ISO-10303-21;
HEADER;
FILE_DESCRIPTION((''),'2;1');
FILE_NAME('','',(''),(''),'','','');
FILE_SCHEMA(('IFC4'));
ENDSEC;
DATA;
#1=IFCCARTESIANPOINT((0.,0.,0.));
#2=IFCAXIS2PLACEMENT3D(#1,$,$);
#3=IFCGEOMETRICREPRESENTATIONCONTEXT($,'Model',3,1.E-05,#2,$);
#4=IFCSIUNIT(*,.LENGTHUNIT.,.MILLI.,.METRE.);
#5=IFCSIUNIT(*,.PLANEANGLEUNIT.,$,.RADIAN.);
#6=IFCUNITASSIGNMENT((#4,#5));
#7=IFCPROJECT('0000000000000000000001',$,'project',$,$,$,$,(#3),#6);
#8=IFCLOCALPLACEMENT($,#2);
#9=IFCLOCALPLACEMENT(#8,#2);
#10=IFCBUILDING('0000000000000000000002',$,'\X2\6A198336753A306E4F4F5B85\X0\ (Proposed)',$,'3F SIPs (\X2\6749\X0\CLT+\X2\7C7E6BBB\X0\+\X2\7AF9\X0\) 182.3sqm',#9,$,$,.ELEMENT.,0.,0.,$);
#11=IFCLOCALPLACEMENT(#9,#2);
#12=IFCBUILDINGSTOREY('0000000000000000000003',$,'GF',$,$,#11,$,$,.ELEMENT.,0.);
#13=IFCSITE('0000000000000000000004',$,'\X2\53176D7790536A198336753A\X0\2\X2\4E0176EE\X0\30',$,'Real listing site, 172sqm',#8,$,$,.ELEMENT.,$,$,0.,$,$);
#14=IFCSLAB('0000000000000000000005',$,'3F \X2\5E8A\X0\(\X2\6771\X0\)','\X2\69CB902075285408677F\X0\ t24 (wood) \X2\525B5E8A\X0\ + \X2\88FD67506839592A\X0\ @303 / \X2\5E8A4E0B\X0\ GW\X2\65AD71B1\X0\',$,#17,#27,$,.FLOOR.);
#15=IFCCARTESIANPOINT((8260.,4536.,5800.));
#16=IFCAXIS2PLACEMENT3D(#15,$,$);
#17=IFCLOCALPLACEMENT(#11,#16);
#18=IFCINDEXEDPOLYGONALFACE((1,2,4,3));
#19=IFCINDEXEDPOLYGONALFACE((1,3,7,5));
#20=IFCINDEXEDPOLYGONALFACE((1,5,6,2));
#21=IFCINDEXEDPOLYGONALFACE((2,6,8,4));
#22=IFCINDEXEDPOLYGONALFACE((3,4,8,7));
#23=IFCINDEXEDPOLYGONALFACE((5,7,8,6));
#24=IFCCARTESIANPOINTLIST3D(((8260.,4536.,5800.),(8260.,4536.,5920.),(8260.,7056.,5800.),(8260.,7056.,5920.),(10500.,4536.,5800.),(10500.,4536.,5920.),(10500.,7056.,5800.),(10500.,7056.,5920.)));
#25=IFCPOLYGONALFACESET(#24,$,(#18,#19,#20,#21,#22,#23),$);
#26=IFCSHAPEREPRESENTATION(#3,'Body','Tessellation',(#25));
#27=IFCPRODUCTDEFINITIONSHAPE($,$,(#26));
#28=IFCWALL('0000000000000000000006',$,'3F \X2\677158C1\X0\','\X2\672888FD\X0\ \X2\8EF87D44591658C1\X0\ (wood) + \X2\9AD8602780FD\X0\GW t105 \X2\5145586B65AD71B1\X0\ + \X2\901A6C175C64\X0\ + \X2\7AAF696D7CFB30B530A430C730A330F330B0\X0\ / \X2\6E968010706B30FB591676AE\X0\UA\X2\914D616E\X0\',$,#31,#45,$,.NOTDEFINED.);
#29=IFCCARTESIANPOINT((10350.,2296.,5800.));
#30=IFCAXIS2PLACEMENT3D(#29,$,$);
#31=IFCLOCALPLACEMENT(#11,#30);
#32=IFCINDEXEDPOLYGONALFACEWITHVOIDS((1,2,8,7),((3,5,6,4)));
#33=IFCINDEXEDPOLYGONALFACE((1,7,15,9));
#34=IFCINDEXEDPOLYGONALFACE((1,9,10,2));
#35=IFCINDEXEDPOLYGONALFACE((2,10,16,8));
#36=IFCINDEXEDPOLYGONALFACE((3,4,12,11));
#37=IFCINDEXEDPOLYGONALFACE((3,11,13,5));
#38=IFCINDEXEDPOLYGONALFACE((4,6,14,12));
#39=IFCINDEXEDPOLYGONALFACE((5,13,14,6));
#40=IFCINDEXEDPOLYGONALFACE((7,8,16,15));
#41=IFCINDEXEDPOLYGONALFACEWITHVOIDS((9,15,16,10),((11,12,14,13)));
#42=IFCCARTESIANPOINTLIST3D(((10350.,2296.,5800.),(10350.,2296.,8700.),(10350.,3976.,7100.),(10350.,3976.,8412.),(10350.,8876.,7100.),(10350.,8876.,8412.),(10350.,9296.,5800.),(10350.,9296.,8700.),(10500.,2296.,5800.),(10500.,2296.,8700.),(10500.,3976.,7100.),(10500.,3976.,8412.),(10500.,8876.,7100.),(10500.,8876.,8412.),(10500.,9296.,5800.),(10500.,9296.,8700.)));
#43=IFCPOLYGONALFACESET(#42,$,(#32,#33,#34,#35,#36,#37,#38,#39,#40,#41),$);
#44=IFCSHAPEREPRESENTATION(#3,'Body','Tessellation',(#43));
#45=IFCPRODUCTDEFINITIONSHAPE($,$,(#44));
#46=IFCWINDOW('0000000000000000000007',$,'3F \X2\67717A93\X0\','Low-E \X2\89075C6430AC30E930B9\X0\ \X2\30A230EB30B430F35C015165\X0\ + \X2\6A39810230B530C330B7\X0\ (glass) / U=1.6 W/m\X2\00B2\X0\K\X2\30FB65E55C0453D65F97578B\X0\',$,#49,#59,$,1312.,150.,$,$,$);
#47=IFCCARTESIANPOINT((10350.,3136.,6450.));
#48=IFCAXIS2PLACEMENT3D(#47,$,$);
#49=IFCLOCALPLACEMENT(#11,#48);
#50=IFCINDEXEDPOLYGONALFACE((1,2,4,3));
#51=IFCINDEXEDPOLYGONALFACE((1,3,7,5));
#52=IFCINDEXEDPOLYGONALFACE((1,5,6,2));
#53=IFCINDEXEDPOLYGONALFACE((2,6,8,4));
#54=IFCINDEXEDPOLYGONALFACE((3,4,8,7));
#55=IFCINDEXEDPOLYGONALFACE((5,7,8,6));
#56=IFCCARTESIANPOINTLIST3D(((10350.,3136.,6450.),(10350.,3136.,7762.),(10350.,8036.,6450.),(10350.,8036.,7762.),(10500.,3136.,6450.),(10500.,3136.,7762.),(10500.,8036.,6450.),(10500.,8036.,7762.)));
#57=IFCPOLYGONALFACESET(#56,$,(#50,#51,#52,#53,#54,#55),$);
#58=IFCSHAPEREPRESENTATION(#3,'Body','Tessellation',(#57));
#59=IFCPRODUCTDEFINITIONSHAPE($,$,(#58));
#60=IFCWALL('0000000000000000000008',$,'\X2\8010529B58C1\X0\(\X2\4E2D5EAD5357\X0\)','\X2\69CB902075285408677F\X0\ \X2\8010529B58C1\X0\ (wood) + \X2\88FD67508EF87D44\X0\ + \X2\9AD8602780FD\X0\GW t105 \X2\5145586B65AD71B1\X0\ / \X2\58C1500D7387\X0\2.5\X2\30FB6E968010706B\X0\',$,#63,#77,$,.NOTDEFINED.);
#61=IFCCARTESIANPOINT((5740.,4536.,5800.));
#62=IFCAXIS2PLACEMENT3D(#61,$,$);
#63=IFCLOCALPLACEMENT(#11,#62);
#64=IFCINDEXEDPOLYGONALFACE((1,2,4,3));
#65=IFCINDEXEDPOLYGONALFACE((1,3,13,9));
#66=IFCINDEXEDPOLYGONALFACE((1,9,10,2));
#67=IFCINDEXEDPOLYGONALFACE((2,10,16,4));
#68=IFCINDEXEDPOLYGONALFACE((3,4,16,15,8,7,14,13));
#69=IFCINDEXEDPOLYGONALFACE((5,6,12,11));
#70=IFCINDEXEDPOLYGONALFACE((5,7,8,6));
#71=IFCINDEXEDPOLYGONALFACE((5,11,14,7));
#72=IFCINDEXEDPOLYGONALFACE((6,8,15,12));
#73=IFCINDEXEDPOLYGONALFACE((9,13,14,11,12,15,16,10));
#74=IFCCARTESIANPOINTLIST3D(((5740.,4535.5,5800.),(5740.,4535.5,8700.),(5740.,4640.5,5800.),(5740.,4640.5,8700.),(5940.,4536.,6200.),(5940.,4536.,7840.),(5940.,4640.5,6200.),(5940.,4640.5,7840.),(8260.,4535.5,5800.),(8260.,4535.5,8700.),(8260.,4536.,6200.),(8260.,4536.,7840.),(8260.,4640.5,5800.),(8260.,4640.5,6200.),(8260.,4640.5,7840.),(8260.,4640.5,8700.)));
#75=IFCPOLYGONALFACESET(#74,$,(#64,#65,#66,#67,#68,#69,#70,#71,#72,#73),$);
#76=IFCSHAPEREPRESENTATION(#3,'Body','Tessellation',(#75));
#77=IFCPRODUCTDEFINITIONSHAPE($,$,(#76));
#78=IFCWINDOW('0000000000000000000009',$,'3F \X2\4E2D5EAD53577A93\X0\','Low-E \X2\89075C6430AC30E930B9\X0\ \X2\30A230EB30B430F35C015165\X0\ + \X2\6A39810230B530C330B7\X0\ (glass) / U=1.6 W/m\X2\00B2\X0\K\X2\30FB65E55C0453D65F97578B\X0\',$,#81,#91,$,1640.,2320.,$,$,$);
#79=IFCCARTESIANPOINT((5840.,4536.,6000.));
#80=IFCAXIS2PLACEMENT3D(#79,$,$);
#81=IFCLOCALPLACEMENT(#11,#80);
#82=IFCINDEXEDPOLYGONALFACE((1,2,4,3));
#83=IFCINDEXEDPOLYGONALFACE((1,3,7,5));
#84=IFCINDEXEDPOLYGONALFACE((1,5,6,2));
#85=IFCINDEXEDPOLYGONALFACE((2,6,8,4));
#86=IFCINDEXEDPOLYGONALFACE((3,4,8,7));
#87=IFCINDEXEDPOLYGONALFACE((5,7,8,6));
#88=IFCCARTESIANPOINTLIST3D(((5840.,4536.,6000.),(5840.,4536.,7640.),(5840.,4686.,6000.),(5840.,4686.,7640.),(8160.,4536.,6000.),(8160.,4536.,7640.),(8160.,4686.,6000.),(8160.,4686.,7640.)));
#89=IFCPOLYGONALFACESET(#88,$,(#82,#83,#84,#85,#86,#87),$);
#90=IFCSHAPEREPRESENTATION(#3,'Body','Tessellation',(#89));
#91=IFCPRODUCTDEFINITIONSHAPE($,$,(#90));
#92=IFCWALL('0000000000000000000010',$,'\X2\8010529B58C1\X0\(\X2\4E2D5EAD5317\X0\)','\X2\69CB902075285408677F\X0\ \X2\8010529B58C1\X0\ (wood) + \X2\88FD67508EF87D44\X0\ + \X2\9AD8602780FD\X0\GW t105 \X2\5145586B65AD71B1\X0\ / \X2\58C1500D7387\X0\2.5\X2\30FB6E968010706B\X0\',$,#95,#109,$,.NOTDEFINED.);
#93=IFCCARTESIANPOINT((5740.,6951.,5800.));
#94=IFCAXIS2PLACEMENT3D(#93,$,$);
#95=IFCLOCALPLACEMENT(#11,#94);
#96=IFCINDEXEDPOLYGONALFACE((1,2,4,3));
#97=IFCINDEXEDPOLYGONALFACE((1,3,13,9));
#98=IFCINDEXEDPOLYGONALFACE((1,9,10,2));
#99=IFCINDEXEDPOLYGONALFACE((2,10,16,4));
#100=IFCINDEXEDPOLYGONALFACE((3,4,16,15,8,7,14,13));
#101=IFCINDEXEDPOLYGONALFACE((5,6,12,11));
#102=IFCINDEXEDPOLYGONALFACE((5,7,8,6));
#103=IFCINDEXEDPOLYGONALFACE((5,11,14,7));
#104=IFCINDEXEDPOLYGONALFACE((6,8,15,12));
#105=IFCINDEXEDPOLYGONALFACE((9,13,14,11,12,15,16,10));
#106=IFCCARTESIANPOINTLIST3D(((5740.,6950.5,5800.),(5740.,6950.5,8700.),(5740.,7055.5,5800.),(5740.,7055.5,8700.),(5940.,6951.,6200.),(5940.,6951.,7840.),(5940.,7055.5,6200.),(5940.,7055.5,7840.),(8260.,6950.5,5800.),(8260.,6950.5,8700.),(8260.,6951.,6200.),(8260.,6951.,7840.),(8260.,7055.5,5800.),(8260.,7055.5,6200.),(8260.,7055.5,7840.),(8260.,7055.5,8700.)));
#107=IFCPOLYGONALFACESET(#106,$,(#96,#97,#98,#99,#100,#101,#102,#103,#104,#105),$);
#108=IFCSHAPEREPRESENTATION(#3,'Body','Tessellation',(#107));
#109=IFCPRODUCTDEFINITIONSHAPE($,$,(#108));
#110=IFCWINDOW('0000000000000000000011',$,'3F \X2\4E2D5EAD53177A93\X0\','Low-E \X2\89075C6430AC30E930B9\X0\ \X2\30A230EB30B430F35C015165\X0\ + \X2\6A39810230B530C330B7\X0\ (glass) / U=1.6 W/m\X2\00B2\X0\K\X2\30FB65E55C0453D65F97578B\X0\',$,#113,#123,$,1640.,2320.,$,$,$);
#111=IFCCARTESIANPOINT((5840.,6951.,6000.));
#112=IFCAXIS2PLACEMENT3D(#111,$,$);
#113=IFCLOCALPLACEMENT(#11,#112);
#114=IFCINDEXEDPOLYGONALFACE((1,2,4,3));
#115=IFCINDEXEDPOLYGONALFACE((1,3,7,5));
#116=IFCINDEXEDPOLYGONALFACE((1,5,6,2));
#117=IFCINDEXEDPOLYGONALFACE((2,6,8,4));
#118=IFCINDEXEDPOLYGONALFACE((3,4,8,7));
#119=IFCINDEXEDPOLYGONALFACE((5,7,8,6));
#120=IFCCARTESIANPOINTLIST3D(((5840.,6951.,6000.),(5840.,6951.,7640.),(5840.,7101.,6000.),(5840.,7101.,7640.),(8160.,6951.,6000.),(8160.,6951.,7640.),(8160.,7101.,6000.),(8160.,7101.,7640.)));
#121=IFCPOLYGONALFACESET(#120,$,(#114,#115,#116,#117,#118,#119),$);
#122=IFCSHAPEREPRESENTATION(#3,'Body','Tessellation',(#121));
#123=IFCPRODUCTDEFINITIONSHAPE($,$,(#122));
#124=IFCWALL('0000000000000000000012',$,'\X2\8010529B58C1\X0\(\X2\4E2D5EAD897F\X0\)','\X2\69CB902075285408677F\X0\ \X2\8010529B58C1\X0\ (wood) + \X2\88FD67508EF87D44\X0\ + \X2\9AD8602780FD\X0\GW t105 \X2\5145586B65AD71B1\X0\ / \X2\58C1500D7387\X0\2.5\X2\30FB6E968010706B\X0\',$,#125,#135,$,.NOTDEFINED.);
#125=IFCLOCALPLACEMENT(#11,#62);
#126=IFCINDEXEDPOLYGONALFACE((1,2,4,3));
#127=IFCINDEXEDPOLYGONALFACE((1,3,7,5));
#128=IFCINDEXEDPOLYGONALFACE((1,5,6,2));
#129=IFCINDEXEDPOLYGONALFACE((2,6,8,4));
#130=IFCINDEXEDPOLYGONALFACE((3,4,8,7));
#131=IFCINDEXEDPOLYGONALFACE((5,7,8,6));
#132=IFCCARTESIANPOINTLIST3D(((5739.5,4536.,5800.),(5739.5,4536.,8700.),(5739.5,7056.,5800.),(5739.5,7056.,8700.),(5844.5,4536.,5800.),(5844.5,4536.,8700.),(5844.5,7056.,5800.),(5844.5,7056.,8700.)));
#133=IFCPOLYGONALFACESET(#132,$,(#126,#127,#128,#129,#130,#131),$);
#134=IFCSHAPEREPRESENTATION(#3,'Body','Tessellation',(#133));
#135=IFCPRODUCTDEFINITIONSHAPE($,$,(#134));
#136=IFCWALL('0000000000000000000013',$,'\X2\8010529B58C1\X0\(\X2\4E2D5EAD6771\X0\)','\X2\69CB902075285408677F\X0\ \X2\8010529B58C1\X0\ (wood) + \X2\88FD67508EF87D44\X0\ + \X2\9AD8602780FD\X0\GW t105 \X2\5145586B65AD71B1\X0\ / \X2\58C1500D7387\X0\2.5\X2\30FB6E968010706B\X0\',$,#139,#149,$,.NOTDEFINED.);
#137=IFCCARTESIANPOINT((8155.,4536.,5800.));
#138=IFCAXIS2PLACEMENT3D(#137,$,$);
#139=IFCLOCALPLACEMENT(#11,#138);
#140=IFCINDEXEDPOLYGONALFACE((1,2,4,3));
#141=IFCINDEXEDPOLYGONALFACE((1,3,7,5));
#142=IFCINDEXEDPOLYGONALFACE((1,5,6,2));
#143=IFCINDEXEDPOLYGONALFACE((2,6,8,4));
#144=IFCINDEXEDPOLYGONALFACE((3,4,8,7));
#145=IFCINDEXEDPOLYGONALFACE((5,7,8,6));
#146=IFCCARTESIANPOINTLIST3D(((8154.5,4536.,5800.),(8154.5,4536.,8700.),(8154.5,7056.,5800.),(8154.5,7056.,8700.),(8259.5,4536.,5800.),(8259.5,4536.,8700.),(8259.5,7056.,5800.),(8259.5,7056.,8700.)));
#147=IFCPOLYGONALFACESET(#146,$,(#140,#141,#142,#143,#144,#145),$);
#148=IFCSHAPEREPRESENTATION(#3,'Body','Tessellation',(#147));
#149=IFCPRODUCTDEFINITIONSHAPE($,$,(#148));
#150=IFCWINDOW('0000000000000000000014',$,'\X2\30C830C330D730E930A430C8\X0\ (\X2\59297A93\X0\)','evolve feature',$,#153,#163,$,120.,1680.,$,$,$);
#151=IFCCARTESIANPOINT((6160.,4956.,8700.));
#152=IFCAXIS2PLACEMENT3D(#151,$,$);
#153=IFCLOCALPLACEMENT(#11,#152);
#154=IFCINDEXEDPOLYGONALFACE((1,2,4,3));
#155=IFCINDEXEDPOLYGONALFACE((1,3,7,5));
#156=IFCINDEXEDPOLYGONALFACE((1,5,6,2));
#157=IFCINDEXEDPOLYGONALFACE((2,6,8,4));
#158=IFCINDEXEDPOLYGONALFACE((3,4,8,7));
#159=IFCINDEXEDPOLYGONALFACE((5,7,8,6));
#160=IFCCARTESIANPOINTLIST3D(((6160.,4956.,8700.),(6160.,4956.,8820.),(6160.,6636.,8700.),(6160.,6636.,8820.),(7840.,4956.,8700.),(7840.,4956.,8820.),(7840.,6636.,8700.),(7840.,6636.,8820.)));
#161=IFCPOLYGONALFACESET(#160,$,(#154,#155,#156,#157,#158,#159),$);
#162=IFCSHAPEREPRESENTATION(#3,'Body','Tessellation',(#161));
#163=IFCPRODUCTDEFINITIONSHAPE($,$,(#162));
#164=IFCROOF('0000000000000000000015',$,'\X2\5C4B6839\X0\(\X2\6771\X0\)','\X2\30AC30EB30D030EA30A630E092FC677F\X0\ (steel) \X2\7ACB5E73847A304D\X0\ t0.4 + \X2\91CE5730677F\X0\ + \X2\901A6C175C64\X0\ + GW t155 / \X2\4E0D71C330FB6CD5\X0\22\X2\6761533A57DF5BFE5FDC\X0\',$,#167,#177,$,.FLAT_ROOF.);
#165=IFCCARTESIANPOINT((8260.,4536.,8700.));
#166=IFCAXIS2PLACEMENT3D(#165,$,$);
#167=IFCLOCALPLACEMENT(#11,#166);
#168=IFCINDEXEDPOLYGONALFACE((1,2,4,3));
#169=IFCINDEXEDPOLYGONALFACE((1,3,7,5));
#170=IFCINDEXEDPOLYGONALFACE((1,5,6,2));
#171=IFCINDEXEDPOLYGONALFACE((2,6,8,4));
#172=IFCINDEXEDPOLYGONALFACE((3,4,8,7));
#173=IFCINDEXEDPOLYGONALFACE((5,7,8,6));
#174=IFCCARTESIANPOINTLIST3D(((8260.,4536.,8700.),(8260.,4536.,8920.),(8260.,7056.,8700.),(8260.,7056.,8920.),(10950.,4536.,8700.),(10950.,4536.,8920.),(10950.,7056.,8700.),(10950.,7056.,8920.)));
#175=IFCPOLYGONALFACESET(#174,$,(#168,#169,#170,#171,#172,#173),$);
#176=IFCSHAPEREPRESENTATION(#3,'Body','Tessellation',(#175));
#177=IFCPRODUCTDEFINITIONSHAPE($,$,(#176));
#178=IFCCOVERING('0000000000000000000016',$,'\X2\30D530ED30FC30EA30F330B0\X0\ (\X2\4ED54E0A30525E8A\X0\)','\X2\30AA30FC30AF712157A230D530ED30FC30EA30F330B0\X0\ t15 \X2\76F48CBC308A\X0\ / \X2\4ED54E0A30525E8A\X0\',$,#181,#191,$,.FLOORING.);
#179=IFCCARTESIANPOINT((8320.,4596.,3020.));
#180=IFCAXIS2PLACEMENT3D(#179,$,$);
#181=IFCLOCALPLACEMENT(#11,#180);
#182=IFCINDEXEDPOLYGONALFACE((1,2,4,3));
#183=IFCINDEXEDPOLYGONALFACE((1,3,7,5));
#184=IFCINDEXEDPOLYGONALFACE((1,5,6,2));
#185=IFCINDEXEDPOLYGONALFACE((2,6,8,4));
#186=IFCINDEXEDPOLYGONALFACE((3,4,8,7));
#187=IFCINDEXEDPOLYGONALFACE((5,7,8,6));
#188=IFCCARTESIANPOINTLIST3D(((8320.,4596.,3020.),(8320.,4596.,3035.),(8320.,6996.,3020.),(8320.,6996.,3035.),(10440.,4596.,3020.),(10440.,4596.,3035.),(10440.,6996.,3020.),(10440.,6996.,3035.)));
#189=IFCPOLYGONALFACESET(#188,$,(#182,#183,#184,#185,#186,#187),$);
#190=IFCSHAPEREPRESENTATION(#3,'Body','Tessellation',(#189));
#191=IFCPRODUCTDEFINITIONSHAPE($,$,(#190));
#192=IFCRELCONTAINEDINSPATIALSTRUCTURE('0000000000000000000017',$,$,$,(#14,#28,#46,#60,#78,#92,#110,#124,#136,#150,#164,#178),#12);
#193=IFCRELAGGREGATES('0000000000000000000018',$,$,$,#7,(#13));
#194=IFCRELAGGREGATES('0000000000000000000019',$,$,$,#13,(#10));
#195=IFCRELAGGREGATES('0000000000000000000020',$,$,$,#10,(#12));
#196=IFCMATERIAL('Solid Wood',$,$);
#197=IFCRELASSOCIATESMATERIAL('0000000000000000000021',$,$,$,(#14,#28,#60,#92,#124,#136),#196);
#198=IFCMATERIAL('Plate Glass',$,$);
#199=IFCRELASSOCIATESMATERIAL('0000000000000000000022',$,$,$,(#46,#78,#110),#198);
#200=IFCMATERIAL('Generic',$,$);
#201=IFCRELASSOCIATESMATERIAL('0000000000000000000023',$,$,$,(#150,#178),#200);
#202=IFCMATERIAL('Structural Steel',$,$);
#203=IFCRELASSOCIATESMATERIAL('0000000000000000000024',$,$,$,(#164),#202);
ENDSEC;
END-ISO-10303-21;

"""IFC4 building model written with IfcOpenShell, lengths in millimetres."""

from ifc_helpers import new_model, si_unit, frame, frame_2d, origin, place, context, project, spatial, rectangle, extrude, material, element, fill, save


model = new_model("IFC4")

# Units and contexts
model_context = context("Model", 3, precision=1e-05, world=origin())
ifc_project = project(units=[si_unit("LENGTHUNIT", "METRE", prefix="MILLI"), si_unit("PLANEANGLEUNIT", "RADIAN")], contexts=[model_context])

# Site, building, storey
site_placement = place(None, origin())
site = spatial("IfcSite", under=ifc_project, at=site_placement, Name="北海道標茶町2丁目30", ObjectType="Real listing site, 172sqm", CompositionType="ELEMENT", RefElevation=0.0)
building_placement = place(site_placement, origin())
building = spatial("IfcBuilding", under=site, at=building_placement, Name="標茶町の住宅 (Proposed)", ObjectType="3F SIPs (杉CLT+籾殻+竹) 182.3sqm", CompositionType="ELEMENT", ElevationOfRefHeight=0.0, ElevationOfTerrain=0.0)
storey_placement = place(building_placement, origin())
storey = spatial("IfcBuildingStorey", under=building, at=storey_placement, Name="GF", CompositionType="ELEMENT", Elevation=0.0)

# Slab
ifc_material_1 = material(Name="Solid Wood")
slab_placement = place(storey_placement, frame((8260.0, 4536.0, 5800.0)))
element("IfcSlab", 1, at=slab_placement, inside=storey, material=ifc_material_1, Name="3F 床(東)", Description="構造用合板 t24 (wood) 剛床 + 製材根太 @303 / 床下 GW断熱", PredefinedType="FLOOR", context=model_context, shape_type="SweptSolid", body=[
    extrude(rectangle(XDim=2240.0, YDim=2520.0, at=frame_2d((1120.0, 1260.0))), frame((8260.0, 4536.0, 5800.0)), (0.0, 0.0, 1.0), 120.0),
])

# Walls, openings, windows
wall_1_placement = place(storey_placement, frame((10350.0, 2296.0, 5800.0)))
wall_1 = element("IfcWall", 2, at=wall_1_placement, inside=storey, material=ifc_material_1, Name="3F 東壁", Description="木製 軸組外壁 (wood) + 高性能GW t105 充填断熱 + 通気層 + 窯業系サイディング / 準耐火・外皮UA配慮", PredefinedType="NOTDEFINED", context=model_context, shape_type="SweptSolid", body=[
    extrude(rectangle(XDim=150.0, YDim=7000.0, at=frame_2d((75.0, 3500.0))), frame((10350.0, 2296.0, 5800.0)), (0.0, 0.0, 1.0), 2900.0),
])
opening_1_placement = place(storey_placement, frame((10350.0, 3136.0, 6450.0)))
opening_1 = element("IfcOpeningElement", 3, at=opening_1_placement, cuts=wall_1, PredefinedType="NOTDEFINED", context=model_context, shape_type="SweptSolid", body=[
    extrude(rectangle(XDim=150.0, YDim=4900.0, at=frame_2d((75.0, 2450.0))), frame((10350.0, 3136.0, 6450.0)), (0.0, 0.0, 1.0), 1312.0),
])
ifc_material_2 = material(Name="Plate Glass")
window_1_placement = place(storey_placement, frame((10350.0, 3136.0, 6450.0)))
window_1 = element("IfcWindow", 4, at=window_1_placement, inside=storey, material=ifc_material_2, Name="3F 東窓", Description="Low-E 複層ガラス アルゴン封入 + 樹脂サッシ (glass) / U=1.6 W/m²K・日射取得型", OverallHeight=1312.0, OverallWidth=150.0, context=model_context, shape_type="SweptSolid", body=[
    extrude(rectangle(XDim=150.0, YDim=4900.0, at=frame_2d((75.0, 2450.0))), frame((10350.0, 3136.0, 6450.0)), (0.0, 0.0, 1.0), 1312.0),
])
fill(opening_1, window_1)
wall_2_placement = place(storey_placement, frame((5740.0, 4536.0, 5800.0)))
wall_2 = element("IfcWall", 5, at=wall_2_placement, inside=storey, material=ifc_material_1, Name="耐力壁(中庭南)", Description="構造用合板 耐力壁 (wood) + 製材軸組 + 高性能GW t105 充填断熱 / 壁倍率2.5・準耐火", PredefinedType="NOTDEFINED", context=model_context, shape_type="SweptSolid", body=[
    extrude(rectangle(XDim=2520.0, YDim=105.0, at=frame_2d((1260.0, 52.0))), frame((5740.0, 4536.0, 5800.0)), (0.0, 0.0, 1.0), 2900.0),
])
opening_2_placement = place(storey_placement, frame((5840.0, 4536.0, 6000.0)))
opening_2 = element("IfcOpeningElement", 6, at=opening_2_placement, cuts=wall_2, PredefinedType="NOTDEFINED", context=model_context, shape_type="SweptSolid", body=[
    extrude(rectangle(XDim=2320.0, YDim=150.0, at=frame_2d((1160.0, 75.0))), frame((5840.0, 4536.0, 6000.0)), (0.0, 0.0, 1.0), 1640.0),
])
window_2_placement = place(storey_placement, frame((5840.0, 4536.0, 6000.0)))
window_2 = element("IfcWindow", 7, at=window_2_placement, inside=storey, material=ifc_material_2, Name="3F 中庭南窓", Description="Low-E 複層ガラス アルゴン封入 + 樹脂サッシ (glass) / U=1.6 W/m²K・日射取得型", OverallHeight=1640.0, OverallWidth=2320.0, context=model_context, shape_type="SweptSolid", body=[
    extrude(rectangle(XDim=2320.0, YDim=150.0, at=frame_2d((1160.0, 75.0))), frame((5840.0, 4536.0, 6000.0)), (0.0, 0.0, 1.0), 1640.0),
])
fill(opening_2, window_2)
wall_3_placement = place(storey_placement, frame((5740.0, 6951.0, 5800.0)))
wall_3 = element("IfcWall", 8, at=wall_3_placement, inside=storey, material=ifc_material_1, Name="耐力壁(中庭北)", Description="構造用合板 耐力壁 (wood) + 製材軸組 + 高性能GW t105 充填断熱 / 壁倍率2.5・準耐火", PredefinedType="NOTDEFINED", context=model_context, shape_type="SweptSolid", body=[
    extrude(rectangle(XDim=2520.0, YDim=105.0, at=frame_2d((1260.0, 52.0))), frame((5740.0, 6951.0, 5800.0)), (0.0, 0.0, 1.0), 2900.0),
])
opening_3_placement = place(storey_placement, frame((5840.0, 6951.0, 6000.0)))
opening_3 = element("IfcOpeningElement", 9, at=opening_3_placement, cuts=wall_3, PredefinedType="NOTDEFINED", context=model_context, shape_type="SweptSolid", body=[
    extrude(rectangle(XDim=2320.0, YDim=150.0, at=frame_2d((1160.0, 75.0))), frame((5840.0, 6951.0, 6000.0)), (0.0, 0.0, 1.0), 1640.0),
])
window_3_placement = place(storey_placement, frame((5840.0, 6951.0, 6000.0)))
window_3 = element("IfcWindow", 10, at=window_3_placement, inside=storey, material=ifc_material_2, Name="3F 中庭北窓", Description="Low-E 複層ガラス アルゴン封入 + 樹脂サッシ (glass) / U=1.6 W/m²K・日射取得型", OverallHeight=1640.0, OverallWidth=2320.0, context=model_context, shape_type="SweptSolid", body=[
    extrude(rectangle(XDim=2320.0, YDim=150.0, at=frame_2d((1160.0, 75.0))), frame((5840.0, 6951.0, 6000.0)), (0.0, 0.0, 1.0), 1640.0),
])
fill(opening_3, window_3)

# Walls
wall_4_placement = place(storey_placement, frame((5740.0, 4536.0, 5800.0)))
element("IfcWall", 11, at=wall_4_placement, inside=storey, material=ifc_material_1, Name="耐力壁(中庭西)", Description="構造用合板 耐力壁 (wood) + 製材軸組 + 高性能GW t105 充填断熱 / 壁倍率2.5・準耐火", PredefinedType="NOTDEFINED", context=model_context, shape_type="SweptSolid", body=[
    extrude(rectangle(XDim=105.0, YDim=2520.0, at=frame_2d((52.0, 1260.0))), frame((5740.0, 4536.0, 5800.0)), (0.0, 0.0, 1.0), 2900.0),
])
wall_5_placement = place(storey_placement, frame((8155.0, 4536.0, 5800.0)))
element("IfcWall", 12, at=wall_5_placement, inside=storey, material=ifc_material_1, Name="耐力壁(中庭東)", Description="構造用合板 耐力壁 (wood) + 製材軸組 + 高性能GW t105 充填断熱 / 壁倍率2.5・準耐火", PredefinedType="NOTDEFINED", context=model_context, shape_type="SweptSolid", body=[
    extrude(rectangle(XDim=105.0, YDim=2520.0, at=frame_2d((52.0, 1260.0))), frame((8155.0, 4536.0, 5800.0)), (0.0, 0.0, 1.0), 2900.0),
])

# Window
ifc_material_3 = material(Name="Generic")
window_4_placement = place(storey_placement, frame((6160.0, 4956.0, 8700.0)))
element("IfcWindow", 13, at=window_4_placement, inside=storey, material=ifc_material_3, Name="トップライト (天窓)", Description="evolve feature", OverallHeight=120.0, OverallWidth=1680.0, context=model_context, shape_type="SweptSolid", body=[
    extrude(rectangle(XDim=1680.0, YDim=1680.0, at=frame_2d((840.0, 840.0))), frame((6160.0, 4956.0, 8700.0)), (0.0, 0.0, 1.0), 120.0),
])

# Roof
ifc_material_4 = material(Name="Structural Steel")
for number, where, name in (
    (14, (8260.0, 4536.0, 8700.0), "屋根(東)"),
):
    element("IfcRoof", number, at=place(storey_placement, frame(where)), inside=storey, material=ifc_material_4, Name=name, Description="ガルバリウム鋼板 (steel) 立平葺き t0.4 + 野地板 + 通気層 + GW t155 / 不燃・法22条区域対応", PredefinedType="FLAT_ROOF", context=model_context, shape_type="SweptSolid", body=[
        extrude(rectangle(XDim=2690.0, YDim=2520.0, at=frame_2d((1345.0, 1260.0))), frame((8260.0, 4536.0, 8700.0)), (0.0, 0.0, 1.0), 220.0),
    ])

# Covering
covering_1_placement = place(storey_placement, frame((8320.0, 4596.0, 3020.0)))
element("IfcCovering", 15, at=covering_1_placement, inside=storey, material=ifc_material_3, Name="フローリング (仕上げ床)", Description="オーク無垢フローリング t15 直貼り / 仕上げ床", PredefinedType="FLOORING", context=model_context, shape_type="SweptSolid", body=[
    extrude(rectangle(XDim=2120.0, YDim=2400.0, at=frame_2d((1060.0, 1200.0))), frame((8320.0, 4596.0, 3020.0)), (0.0, 0.0, 1.0), 15.0),
])

save(model, "model.ifc")
